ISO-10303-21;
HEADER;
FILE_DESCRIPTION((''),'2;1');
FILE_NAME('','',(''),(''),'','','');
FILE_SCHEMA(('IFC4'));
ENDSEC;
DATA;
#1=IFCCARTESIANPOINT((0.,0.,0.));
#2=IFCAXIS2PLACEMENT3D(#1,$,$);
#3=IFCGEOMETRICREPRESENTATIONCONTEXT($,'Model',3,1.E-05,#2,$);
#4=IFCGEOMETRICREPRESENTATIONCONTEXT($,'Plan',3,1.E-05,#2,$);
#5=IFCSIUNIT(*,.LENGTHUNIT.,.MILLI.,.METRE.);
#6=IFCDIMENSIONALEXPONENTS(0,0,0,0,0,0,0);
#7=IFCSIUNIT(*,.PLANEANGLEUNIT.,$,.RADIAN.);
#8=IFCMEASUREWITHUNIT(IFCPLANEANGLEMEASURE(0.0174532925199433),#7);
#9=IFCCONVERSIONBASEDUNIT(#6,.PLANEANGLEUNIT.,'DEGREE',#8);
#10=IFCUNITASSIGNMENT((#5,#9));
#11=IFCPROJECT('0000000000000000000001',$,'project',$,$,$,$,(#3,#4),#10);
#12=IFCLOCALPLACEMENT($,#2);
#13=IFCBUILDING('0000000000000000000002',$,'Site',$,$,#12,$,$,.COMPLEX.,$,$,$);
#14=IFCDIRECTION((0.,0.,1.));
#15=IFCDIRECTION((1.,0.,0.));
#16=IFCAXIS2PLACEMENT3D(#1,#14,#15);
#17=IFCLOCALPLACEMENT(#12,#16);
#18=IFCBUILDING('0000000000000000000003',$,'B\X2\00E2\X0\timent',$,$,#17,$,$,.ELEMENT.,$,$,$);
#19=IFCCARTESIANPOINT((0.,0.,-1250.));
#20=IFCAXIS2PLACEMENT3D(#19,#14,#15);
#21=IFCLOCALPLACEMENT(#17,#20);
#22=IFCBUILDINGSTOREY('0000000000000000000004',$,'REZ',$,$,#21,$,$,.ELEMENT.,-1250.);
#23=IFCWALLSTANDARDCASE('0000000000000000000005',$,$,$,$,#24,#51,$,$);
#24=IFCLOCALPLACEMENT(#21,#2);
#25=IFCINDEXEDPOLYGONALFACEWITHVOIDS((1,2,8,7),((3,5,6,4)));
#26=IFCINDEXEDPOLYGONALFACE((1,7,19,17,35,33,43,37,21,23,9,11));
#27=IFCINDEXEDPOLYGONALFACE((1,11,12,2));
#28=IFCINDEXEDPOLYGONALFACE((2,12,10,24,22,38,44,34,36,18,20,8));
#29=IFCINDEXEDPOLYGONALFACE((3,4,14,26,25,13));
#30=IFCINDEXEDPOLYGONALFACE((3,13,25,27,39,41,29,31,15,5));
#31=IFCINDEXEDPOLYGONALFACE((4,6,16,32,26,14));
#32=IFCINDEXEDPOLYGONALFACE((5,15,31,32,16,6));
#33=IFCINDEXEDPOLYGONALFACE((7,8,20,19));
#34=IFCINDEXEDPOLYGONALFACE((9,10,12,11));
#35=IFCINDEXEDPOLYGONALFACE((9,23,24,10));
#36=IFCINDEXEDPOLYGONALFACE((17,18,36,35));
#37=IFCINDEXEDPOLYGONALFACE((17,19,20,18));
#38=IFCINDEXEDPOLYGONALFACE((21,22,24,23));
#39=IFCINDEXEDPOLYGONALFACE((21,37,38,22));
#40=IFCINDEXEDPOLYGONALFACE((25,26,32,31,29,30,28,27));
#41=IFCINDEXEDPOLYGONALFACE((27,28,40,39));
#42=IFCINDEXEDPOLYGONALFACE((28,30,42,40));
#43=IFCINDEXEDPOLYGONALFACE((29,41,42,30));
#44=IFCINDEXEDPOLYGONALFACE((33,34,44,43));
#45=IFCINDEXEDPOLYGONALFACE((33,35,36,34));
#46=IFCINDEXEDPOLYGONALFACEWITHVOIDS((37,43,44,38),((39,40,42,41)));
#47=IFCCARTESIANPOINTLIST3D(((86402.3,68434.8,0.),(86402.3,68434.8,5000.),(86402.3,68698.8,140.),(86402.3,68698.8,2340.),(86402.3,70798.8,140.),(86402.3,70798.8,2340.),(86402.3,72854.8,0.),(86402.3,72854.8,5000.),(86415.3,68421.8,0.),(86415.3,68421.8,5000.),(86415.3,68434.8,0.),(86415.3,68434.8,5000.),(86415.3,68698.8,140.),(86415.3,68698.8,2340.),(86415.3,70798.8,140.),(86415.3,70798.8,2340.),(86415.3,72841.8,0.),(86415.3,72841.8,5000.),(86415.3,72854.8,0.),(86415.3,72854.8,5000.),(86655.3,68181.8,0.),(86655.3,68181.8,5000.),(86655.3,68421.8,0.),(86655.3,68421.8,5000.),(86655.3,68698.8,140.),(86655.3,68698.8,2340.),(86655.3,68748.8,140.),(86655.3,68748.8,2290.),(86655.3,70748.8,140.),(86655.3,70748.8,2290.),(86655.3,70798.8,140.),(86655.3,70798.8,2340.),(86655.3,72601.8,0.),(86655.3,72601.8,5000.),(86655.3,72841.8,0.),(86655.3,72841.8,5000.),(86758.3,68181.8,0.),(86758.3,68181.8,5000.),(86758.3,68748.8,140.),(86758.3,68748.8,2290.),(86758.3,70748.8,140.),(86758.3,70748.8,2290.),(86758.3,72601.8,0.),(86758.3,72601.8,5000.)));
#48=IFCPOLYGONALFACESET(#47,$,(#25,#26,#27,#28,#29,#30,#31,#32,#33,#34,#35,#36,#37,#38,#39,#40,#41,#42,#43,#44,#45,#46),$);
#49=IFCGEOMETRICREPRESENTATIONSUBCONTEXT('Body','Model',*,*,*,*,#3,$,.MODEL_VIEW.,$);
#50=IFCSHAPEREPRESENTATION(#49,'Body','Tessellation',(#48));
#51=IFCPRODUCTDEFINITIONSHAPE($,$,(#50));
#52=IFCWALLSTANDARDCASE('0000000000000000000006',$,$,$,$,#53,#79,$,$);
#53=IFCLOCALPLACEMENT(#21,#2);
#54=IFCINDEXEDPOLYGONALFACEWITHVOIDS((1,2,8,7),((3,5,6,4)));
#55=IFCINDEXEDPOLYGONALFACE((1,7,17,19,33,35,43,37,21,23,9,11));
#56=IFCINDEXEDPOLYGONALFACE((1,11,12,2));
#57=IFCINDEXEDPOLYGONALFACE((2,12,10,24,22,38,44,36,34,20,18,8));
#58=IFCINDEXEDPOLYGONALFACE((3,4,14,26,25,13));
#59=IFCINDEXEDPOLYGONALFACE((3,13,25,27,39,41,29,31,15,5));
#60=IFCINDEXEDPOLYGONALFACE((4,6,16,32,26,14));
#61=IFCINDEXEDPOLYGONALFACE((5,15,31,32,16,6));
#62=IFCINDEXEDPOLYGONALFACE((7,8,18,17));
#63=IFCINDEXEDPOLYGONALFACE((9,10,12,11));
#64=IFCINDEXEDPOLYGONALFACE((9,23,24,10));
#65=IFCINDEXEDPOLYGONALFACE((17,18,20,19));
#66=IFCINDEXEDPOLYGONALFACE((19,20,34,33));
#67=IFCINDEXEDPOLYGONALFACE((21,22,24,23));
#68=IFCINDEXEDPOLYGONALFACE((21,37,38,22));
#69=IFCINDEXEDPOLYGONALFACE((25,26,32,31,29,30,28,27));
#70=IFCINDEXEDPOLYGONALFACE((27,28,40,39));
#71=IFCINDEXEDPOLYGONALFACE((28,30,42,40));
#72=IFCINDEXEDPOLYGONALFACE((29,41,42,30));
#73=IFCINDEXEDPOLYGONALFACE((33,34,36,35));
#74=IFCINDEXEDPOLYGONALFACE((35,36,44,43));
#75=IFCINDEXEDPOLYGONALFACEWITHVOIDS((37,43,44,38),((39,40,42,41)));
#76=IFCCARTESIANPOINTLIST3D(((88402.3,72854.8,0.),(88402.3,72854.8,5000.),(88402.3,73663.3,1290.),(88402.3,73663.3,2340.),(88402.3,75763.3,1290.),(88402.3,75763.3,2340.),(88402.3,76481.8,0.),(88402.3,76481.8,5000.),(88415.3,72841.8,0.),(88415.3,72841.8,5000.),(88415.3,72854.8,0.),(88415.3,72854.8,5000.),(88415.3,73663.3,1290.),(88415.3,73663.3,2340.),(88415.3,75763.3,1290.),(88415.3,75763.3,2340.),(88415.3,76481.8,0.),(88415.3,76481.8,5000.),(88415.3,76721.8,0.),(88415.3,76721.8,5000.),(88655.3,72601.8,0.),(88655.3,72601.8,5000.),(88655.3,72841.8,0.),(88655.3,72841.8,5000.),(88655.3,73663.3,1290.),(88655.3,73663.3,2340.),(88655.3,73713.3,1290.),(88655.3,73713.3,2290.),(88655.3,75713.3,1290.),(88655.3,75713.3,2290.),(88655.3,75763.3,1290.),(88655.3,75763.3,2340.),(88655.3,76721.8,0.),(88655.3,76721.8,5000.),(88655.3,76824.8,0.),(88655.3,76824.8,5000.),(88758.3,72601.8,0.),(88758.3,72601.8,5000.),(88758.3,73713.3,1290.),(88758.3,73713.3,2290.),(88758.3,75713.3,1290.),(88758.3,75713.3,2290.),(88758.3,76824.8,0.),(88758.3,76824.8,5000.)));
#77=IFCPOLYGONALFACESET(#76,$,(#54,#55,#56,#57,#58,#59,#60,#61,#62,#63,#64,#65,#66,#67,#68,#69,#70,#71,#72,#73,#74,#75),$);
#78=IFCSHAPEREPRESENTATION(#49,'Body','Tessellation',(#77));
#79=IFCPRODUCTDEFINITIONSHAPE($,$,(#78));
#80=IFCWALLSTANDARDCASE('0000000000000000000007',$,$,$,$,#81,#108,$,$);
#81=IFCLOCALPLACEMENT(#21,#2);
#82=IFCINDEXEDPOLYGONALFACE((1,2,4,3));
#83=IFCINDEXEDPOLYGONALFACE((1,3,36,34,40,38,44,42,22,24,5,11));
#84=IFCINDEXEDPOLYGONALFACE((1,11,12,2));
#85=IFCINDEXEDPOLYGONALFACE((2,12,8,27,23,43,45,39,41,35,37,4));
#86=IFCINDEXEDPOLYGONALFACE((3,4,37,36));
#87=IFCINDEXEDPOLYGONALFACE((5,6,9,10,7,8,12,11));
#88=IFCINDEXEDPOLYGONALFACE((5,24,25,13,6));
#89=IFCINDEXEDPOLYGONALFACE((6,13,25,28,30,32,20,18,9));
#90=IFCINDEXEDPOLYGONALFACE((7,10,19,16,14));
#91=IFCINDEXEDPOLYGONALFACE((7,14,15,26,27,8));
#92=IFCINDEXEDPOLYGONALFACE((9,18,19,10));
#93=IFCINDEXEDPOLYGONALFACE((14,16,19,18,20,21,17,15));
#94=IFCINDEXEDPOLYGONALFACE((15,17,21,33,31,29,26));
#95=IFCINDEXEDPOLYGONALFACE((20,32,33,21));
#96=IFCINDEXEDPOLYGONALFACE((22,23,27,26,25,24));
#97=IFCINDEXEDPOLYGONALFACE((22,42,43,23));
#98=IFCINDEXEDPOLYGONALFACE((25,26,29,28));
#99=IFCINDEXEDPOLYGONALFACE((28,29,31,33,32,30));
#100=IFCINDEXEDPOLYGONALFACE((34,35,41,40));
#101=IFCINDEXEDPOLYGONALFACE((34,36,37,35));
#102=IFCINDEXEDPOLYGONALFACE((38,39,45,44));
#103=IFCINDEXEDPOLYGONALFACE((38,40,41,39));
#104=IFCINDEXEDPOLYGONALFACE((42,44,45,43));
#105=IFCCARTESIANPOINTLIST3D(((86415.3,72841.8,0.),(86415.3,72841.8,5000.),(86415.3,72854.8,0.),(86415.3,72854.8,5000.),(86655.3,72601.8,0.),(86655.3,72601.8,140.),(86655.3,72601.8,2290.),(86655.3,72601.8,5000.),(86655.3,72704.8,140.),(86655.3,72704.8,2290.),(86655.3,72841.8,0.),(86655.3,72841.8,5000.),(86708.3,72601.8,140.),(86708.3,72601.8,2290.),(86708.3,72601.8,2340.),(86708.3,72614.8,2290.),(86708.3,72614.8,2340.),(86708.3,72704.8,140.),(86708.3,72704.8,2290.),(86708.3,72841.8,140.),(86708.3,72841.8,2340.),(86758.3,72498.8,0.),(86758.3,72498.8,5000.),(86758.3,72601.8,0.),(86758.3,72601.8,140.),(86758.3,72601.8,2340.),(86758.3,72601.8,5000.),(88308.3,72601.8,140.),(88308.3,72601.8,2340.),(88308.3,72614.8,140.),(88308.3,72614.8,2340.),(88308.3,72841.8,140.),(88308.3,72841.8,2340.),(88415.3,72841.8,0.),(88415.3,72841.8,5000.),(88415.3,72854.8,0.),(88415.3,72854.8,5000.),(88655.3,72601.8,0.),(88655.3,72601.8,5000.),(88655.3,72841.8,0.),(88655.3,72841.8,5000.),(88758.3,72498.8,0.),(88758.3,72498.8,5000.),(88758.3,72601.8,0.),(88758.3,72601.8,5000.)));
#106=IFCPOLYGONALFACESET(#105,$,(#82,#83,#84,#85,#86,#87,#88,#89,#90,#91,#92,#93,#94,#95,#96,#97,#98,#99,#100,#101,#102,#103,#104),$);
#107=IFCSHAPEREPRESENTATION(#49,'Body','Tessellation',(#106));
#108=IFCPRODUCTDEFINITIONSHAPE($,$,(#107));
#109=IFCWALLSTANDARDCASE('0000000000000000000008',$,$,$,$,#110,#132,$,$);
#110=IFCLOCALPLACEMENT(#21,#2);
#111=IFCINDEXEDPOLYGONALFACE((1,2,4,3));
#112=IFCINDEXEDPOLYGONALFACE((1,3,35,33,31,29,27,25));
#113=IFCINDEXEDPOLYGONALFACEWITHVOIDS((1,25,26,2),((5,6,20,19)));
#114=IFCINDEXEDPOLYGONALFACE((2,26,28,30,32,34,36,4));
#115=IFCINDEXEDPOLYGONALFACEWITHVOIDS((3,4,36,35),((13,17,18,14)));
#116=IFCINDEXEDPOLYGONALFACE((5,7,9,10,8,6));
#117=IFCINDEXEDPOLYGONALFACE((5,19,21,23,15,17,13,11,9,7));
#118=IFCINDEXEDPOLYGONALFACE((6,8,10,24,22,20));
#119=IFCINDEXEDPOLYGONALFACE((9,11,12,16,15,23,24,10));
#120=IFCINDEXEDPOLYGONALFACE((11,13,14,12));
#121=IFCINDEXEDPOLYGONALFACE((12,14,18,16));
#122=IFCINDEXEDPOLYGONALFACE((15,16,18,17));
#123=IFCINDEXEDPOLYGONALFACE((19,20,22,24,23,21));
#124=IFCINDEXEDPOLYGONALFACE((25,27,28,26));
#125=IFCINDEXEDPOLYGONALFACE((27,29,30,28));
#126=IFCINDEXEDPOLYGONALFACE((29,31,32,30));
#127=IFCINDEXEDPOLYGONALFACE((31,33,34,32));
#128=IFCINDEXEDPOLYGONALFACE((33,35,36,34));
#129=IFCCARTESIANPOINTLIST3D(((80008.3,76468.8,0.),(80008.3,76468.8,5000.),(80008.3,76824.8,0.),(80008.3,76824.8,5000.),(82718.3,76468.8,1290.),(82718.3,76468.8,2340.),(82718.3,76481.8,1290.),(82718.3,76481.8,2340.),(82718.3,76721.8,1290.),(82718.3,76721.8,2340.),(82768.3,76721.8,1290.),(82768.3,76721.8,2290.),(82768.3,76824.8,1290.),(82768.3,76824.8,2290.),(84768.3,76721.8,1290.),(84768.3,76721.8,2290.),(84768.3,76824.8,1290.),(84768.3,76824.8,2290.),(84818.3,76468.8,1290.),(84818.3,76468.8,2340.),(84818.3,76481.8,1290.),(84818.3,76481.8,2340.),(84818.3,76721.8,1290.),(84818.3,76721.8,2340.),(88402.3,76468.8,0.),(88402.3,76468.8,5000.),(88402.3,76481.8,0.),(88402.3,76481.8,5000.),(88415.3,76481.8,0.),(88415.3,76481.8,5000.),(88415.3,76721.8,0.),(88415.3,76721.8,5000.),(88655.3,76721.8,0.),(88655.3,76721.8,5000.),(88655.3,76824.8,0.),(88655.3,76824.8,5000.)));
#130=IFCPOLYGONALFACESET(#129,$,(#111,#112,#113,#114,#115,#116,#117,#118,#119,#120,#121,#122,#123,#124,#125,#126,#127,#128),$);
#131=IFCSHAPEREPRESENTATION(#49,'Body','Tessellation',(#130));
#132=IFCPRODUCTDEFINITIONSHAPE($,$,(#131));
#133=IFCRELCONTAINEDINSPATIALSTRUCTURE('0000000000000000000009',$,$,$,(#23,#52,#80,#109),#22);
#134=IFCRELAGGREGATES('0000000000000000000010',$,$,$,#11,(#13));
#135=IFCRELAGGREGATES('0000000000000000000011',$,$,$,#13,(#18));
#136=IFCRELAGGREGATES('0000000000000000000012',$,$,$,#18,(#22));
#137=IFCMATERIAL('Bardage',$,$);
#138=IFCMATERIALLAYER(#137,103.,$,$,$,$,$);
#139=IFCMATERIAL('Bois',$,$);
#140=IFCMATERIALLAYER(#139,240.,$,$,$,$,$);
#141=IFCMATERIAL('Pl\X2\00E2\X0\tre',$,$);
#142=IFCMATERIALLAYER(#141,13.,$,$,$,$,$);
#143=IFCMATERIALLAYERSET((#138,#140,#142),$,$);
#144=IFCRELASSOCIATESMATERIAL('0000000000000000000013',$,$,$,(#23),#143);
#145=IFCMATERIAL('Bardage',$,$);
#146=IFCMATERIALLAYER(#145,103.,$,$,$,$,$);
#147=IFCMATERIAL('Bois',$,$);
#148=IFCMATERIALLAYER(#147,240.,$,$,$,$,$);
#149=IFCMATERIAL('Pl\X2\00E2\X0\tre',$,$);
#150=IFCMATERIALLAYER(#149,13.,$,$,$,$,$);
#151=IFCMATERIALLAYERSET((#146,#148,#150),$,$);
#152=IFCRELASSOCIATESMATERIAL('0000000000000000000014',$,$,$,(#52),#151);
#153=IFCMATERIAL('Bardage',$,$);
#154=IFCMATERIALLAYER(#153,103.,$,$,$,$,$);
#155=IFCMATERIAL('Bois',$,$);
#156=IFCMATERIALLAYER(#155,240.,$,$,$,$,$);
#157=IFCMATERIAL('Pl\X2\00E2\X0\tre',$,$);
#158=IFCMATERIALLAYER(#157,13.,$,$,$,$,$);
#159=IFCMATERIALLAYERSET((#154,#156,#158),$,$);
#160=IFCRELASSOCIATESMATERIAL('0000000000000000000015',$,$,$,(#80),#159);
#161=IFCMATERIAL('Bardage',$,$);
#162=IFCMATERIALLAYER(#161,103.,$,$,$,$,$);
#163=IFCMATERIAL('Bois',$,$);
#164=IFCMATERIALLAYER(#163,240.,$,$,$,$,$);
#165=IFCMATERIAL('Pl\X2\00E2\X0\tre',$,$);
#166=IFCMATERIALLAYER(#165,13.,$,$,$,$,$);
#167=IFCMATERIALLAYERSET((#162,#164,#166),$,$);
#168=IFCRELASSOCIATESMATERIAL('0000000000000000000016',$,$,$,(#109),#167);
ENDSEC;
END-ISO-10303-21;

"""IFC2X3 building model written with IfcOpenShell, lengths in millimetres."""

from ifc_helpers import new_model, entity, si_unit, converted_unit, frame, frame_2d, origin, origin_with_axes, place, context, subcontext, project, spatial, polyline, rectangle, outline, extrude, material, layer, layer_set, layer_usage, element, save


model = new_model("IFC2X3")

# Units and contexts
model_context = context("Model", 3, precision=1e-05, world=origin())
plan_context = context("Plan", 3, precision=1e-05, world=origin())
body_context = subcontext(model_context, "Body", "Model", "MODEL_VIEW")
ifc_project = project(units=[si_unit("LENGTHUNIT", "METRE", prefix="MILLI"), converted_unit("PLANEANGLEUNIT", "DEGREE", entity("IfcPlaneAngleMeasure", 0.0174532925199433), si_unit("PLANEANGLEUNIT", "RADIAN"), dimensions=[0, 0, 0, 0, 0, 0, 0])], contexts=[model_context, plan_context])

# Buildings, storey
building_1_placement = place(None, origin())
building_1 = spatial("IfcBuilding", under=ifc_project, at=building_1_placement, Name="Site", CompositionType="COMPLEX")
building_2_placement = place(building_1_placement, origin_with_axes())
building_2 = spatial("IfcBuilding", under=building_1, at=building_2_placement, Name="Bâtiment", CompositionType="ELEMENT")
storey_placement = place(building_2_placement, frame((0.0, 0.0, -1250.0), z_axis=(0.0, 0.0, 1.0), x_axis=(1.0, 0.0, 0.0)))
storey = spatial("IfcBuildingStorey", under=building_2, at=storey_placement, Name="REZ", CompositionType="ELEMENT", Elevation=-1250.0)

# Walls, openings
ifc_material_1 = material(Name="Bardage")
ifc_layer_1 = layer(ifc_material_1, 103.0)
ifc_material_2 = material(Name="Bois")
ifc_layer_2 = layer(ifc_material_2, 240.0)
ifc_material_3 = material(Name="Plâtre")
ifc_layer_3 = layer(ifc_material_3, 13.0)
ifc_layer_set_1 = layer_set([ifc_layer_1, ifc_layer_2, ifc_layer_3])
ifc_layer_usage_1 = layer_usage(ifc_layer_set_1, "AXIS2", "POSITIVE", 0.0)
wall_1_placement = place(storey_placement, frame((86758.3, 68181.8, 0.0), z_axis=(0.0, 0.0, 1.0), x_axis=(0.0, 1.0, 0.0)))
wall_1 = element("IfcWallStandardCase", 1, at=wall_1_placement, inside=storey, material=ifc_layer_usage_1, context=body_context, shape_type="SweptSolid", body=[
    extrude(outline(polyline([(0.0, 0.0), (4420.0, 0.0), (4420.0, 103.0), (4660.0, 103.0), (4660.0, 343.0), (4673.0, 343.0), (4673.0, 356.0), (253.0, 356.0), (253.0, 343.0), (240.0, 343.0), (240.0, 103.0), (0.0, 103.0), (0.0, 0.0)])), origin_with_axes(), (0.0, 0.0, 1.0), 5000.0),
])
opening_1_placement = place(wall_1_placement, frame((567.0, 0.0, 140.0), z_axis=(0.0, 1.0, 0.0), x_axis=(0.0, 0.0, 1.0)))
element("IfcOpeningElement", 2, at=opening_1_placement, cuts=wall_1, ObjectType="Opening", context=body_context, shape_type="SweptSolid", body=[
    extrude(rectangle(XDim=2150.0, YDim=2000.0, at=frame_2d((1075.0, 1000.0), x_axis=(1.0, 0.0))), origin_with_axes(), (0.0, 0.0, 1.0), 103.0),
    extrude(rectangle(XDim=2200.0, YDim=2100.0, at=frame_2d((1100.0, 1050.0), x_axis=(1.0, 0.0))), frame((0.0, -50.0, 103.0), z_axis=(0.0, 0.0, 1.0), x_axis=(1.0, 0.0, 0.0)), (0.0, 0.0, 1.0), 240.0),
    extrude(rectangle(XDim=2200.0, YDim=2100.0, at=frame_2d((1100.0, 1050.0), x_axis=(1.0, 0.0))), frame((0.0, -50.0, 343.0), z_axis=(0.0, 0.0, 1.0), x_axis=(1.0, 0.0, 0.0)), (0.0, 0.0, 1.0), 13.0),
])
ifc_material_4 = material(Name="Bardage")
ifc_layer_4 = layer(ifc_material_4, 103.0)
ifc_material_5 = material(Name="Bois")
ifc_layer_5 = layer(ifc_material_5, 240.0)
ifc_material_6 = material(Name="Plâtre")
ifc_layer_6 = layer(ifc_material_6, 13.0)
ifc_layer_set_2 = layer_set([ifc_layer_4, ifc_layer_5, ifc_layer_6])
ifc_layer_usage_2 = layer_usage(ifc_layer_set_2, "AXIS2", "POSITIVE", 0.0)
wall_2_placement = place(storey_placement, frame((88758.3, 72601.8, 0.0), z_axis=(0.0, 0.0, 1.0), x_axis=(0.0, 1.0, 0.0)))
wall_2 = element("IfcWallStandardCase", 3, at=wall_2_placement, inside=storey, material=ifc_layer_usage_2, context=body_context, shape_type="SweptSolid", body=[
    extrude(outline(polyline([(0.0, 0.0), (4223.0, 0.0), (4223.0, 103.0), (4120.0, 103.0), (4120.0, 343.0), (3880.0, 343.0), (3880.0, 356.0), (253.0, 356.0), (253.0, 343.0), (240.0, 343.0), (240.0, 103.0), (0.0, 103.0), (0.0, 0.0)])), origin_with_axes(), (0.0, 0.0, 1.0), 5000.0),
])
opening_2_placement = place(wall_2_placement, frame((1111.5, 0.0, 1290.0), z_axis=(0.0, 1.0, 0.0), x_axis=(0.0, 0.0, 1.0)))
element("IfcOpeningElement", 4, at=opening_2_placement, cuts=wall_2, ObjectType="Opening", context=body_context, shape_type="SweptSolid", body=[
    extrude(rectangle(XDim=1000.0, YDim=2000.0, at=frame_2d((500.0, 1000.0), x_axis=(1.0, 0.0))), origin_with_axes(), (0.0, 0.0, 1.0), 103.0),
    extrude(rectangle(XDim=1050.0, YDim=2100.0, at=frame_2d((525.0, 1050.0), x_axis=(1.0, 0.0))), frame((0.0, -50.0, 103.0), z_axis=(0.0, 0.0, 1.0), x_axis=(1.0, 0.0, 0.0)), (0.0, 0.0, 1.0), 240.0),
    extrude(rectangle(XDim=1050.0, YDim=2100.0, at=frame_2d((525.0, 1050.0), x_axis=(1.0, 0.0))), frame((0.0, -50.0, 343.0), z_axis=(0.0, 0.0, 1.0), x_axis=(1.0, 0.0, 0.0)), (0.0, 0.0, 1.0), 13.0),
])
ifc_material_7 = material(Name="Bardage")
ifc_layer_7 = layer(ifc_material_7, 103.0)
ifc_material_8 = material(Name="Bois")
ifc_layer_8 = layer(ifc_material_8, 240.0)
ifc_material_9 = material(Name="Plâtre")
ifc_layer_9 = layer(ifc_material_9, 13.0)
ifc_layer_set_3 = layer_set([ifc_layer_7, ifc_layer_8, ifc_layer_9])
ifc_layer_usage_3 = layer_usage(ifc_layer_set_3, "AXIS2", "POSITIVE", 0.0)
wall_3_placement = place(storey_placement, frame((86758.3, 72498.8, 0.0), z_axis=(0.0, 0.0, 1.0), x_axis=(1.0, 0.0, 0.0)))
wall_3 = element("IfcWallStandardCase", 5, at=wall_3_placement, inside=storey, material=ifc_layer_usage_3, context=body_context, shape_type="SweptSolid", body=[
    extrude(outline(polyline([(0.0, 0.0), (2000.0, 0.0), (2000.0, 103.0), (1897.0, 103.0), (1897.0, 343.0), (1657.0, 343.0), (1657.0, 356.0), (-343.0, 356.0), (-343.0, 343.0), (-103.0, 343.0), (-103.0, 103.0), (0.0, 103.0), (0.0, 0.0)])), origin_with_axes(), (0.0, 0.0, 1.0), 5000.0),
])
opening_3_placement = place(wall_3_placement, frame((-50.0, 103.0, 140.0), z_axis=(0.0, 1.0, 0.0), x_axis=(0.0, 0.0, 1.0)))
element("IfcOpeningElement", 6, at=opening_3_placement, cuts=wall_3, ObjectType="Opening", context=body_context, shape_type="SweptSolid", body=[
    extrude(rectangle(XDim=2200.0, YDim=1600.0, at=frame_2d((1100.0, 800.0), x_axis=(1.0, 0.0))), origin_with_axes(), (0.0, 0.0, 1.0), 13.0),
    extrude(rectangle(XDim=2200.0, YDim=1600.0, at=frame_2d((1100.0, 800.0), x_axis=(1.0, 0.0))), origin_with_axes(), (0.0, 0.0, 1.0), 240.0),
    extrude(rectangle(XDim=2150.0, YDim=1500.0, at=frame_2d((1075.0, 750.0), x_axis=(1.0, 0.0))), frame((0.0, -114.5, 0.0), z_axis=(0.0, 0.0, 1.0), x_axis=(1.0, 0.0, 0.0)), (0.0, 0.0, 1.0), 103.0),
])
ifc_material_10 = material(Name="Bardage")
ifc_layer_10 = layer(ifc_material_10, 103.0)
ifc_material_11 = material(Name="Bois")
ifc_layer_11 = layer(ifc_material_11, 240.0)
ifc_material_12 = material(Name="Plâtre")
ifc_layer_12 = layer(ifc_material_12, 13.0)
ifc_layer_set_4 = layer_set([ifc_layer_10, ifc_layer_11, ifc_layer_12])
ifc_layer_usage_4 = layer_usage(ifc_layer_set_4, "AXIS2", "POSITIVE", 0.0)
wall_4_placement = place(storey_placement, frame((88655.3, 76824.8, 0.0), z_axis=(0.0, 0.0, 1.0), x_axis=(-1.0, 0.0, 0.0)))
wall_4 = element("IfcWallStandardCase", 7, at=wall_4_placement, inside=storey, material=ifc_layer_usage_4, context=body_context, shape_type="SweptSolid", body=[
    extrude(outline(polyline([(253.0, 356.0), (253.0, 343.0), (240.0, 343.0), (240.0, 103.0), (0.0, 103.0), (0.0, 0.0), (8647.0, 0.0), (8647.0, 356.0), (253.0, 356.0)])), origin_with_axes(), (0.0, 0.0, 1.0), 5000.0),
])
opening_4_placement = place(wall_4_placement, frame((3887.0, 0.0, 1290.0), z_axis=(0.0, 1.0, 0.0), x_axis=(0.0, 0.0, 1.0)))
element("IfcOpeningElement", 8, at=opening_4_placement, cuts=wall_4, ObjectType="Opening", context=body_context, shape_type="SweptSolid", body=[
    extrude(rectangle(XDim=1000.0, YDim=2000.0, at=frame_2d((500.0, 1000.0), x_axis=(1.0, 0.0))), origin_with_axes(), (0.0, 0.0, 1.0), 103.0),
    extrude(rectangle(XDim=1050.0, YDim=2100.0, at=frame_2d((525.0, 1050.0), x_axis=(1.0, 0.0))), frame((0.0, -50.0, 103.0), z_axis=(0.0, 0.0, 1.0), x_axis=(1.0, 0.0, 0.0)), (0.0, 0.0, 1.0), 240.0),
    extrude(rectangle(XDim=1050.0, YDim=2100.0, at=frame_2d((525.0, 1050.0), x_axis=(1.0, 0.0))), frame((0.0, -50.0, 343.0), z_axis=(0.0, 0.0, 1.0), x_axis=(1.0, 0.0, 0.0)), (0.0, 0.0, 1.0), 13.0),
])

save(model, "model.ifc")
